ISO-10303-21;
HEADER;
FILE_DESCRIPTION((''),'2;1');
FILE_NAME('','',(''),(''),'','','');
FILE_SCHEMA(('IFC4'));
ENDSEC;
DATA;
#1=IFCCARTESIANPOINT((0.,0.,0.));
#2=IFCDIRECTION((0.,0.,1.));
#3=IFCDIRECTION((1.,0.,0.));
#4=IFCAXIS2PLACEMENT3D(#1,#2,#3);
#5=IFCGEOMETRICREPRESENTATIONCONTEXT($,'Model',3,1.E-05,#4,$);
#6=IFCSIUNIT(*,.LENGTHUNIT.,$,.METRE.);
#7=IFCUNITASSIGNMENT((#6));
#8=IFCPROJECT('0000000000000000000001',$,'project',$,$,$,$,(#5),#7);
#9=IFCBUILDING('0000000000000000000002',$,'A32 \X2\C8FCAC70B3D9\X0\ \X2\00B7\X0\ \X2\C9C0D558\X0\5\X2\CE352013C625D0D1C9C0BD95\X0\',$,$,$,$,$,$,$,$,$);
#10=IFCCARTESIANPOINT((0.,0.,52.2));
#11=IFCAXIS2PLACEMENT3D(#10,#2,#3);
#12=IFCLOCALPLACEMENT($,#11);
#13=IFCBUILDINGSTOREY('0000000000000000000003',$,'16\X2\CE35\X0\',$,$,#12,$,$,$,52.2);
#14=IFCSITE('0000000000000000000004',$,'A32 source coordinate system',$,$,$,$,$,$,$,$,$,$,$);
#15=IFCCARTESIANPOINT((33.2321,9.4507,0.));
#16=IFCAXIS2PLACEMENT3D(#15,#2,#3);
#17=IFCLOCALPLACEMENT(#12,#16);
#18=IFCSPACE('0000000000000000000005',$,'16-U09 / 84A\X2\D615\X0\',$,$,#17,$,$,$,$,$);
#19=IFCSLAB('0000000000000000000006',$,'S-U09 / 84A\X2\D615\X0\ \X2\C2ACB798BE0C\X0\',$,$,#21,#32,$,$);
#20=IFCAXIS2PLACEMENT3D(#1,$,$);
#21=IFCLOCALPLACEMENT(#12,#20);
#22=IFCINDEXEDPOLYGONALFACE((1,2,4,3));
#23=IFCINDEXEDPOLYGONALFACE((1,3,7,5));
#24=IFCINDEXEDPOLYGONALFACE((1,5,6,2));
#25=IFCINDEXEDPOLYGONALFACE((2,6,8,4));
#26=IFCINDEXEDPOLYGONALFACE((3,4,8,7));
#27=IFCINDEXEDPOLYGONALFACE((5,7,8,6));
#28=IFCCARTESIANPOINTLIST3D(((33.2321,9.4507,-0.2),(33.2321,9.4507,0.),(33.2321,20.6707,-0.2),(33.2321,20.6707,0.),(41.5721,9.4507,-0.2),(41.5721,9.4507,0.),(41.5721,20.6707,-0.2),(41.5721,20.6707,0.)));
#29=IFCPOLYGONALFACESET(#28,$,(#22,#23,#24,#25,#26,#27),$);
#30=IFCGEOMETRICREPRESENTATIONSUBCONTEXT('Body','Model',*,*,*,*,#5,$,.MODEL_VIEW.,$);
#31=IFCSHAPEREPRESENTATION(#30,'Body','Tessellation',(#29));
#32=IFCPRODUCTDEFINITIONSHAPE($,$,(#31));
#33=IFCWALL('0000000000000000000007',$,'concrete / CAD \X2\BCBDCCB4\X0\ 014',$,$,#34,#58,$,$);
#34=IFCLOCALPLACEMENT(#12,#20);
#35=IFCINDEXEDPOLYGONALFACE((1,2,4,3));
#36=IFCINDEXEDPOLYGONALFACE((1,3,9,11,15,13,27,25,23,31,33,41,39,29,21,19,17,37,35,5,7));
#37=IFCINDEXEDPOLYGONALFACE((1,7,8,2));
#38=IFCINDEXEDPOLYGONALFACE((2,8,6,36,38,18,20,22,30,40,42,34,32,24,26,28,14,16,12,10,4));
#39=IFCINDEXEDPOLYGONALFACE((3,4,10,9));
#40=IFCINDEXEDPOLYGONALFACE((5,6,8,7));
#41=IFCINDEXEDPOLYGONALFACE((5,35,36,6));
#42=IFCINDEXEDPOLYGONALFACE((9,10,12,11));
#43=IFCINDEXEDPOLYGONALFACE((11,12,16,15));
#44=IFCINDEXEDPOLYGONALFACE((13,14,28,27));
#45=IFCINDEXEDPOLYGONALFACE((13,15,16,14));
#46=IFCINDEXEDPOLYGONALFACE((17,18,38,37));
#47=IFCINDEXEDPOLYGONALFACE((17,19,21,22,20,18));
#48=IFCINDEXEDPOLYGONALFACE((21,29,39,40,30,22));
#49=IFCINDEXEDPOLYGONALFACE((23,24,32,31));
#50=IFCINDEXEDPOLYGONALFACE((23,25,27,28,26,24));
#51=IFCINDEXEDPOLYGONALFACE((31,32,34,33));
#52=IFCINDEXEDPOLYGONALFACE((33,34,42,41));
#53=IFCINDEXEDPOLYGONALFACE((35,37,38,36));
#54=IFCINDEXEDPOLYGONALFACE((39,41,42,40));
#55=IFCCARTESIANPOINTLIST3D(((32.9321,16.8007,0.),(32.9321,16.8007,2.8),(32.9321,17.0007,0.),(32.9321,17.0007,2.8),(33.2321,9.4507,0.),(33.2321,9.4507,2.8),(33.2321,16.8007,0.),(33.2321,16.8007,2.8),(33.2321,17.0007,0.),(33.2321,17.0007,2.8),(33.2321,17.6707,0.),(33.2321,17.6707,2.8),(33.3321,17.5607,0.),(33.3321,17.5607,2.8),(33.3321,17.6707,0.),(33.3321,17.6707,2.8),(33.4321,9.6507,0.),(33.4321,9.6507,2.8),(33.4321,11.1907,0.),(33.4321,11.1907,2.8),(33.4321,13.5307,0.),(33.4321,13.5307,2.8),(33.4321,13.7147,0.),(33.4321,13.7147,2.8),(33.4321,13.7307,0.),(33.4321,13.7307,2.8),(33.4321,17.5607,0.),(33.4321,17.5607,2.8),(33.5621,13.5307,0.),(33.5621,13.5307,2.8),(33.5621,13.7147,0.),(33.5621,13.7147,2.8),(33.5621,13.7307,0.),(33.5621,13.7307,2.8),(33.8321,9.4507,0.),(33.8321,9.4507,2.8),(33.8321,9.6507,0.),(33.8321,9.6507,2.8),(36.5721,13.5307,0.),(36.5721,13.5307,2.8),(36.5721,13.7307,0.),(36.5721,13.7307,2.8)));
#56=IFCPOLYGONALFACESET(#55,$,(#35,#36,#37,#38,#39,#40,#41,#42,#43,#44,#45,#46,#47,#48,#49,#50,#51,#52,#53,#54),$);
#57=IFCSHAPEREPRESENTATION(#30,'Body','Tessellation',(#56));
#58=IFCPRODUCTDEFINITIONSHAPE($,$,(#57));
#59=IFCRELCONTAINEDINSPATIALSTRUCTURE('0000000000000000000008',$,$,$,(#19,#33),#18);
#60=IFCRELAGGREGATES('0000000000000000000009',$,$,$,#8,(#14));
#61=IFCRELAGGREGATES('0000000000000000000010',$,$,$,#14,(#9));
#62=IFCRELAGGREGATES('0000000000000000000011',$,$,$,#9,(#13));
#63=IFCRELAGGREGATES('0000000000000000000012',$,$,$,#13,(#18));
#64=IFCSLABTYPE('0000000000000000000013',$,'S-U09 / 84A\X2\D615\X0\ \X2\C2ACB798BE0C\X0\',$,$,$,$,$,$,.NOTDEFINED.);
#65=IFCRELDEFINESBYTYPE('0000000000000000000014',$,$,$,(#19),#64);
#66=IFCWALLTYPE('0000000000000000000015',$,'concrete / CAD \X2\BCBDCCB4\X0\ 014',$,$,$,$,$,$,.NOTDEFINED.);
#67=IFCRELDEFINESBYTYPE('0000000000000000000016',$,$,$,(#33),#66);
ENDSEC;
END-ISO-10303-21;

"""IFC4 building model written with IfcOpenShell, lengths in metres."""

from ifc_helpers import new_model, si_unit, frame, origin, origin_with_axes, place, context, subcontext, project, spatial, polyline, outline, extrude, source, transform, mapped, type_object, type_shapes, element, save


model = new_model("IFC4")

# Units and contexts
model_context = context("Model", 3, precision=1e-05, world=origin_with_axes())
body_context = subcontext(model_context, "Body", "Model", "MODEL_VIEW")
ifc_project = project(units=[si_unit("LENGTHUNIT", "METRE")], contexts=[model_context])

# Site, building, storey, space
storey_placement = place(None, frame((0.0, 0.0, 52.2), z_axis=(0.0, 0.0, 1.0), x_axis=(1.0, 0.0, 0.0)))
space_placement = place(storey_placement, frame((33.2321, 9.4507, 0.0), z_axis=(0.0, 0.0, 1.0), x_axis=(1.0, 0.0, 0.0)))
site = spatial("IfcSite", under=ifc_project, Name="A32 source coordinate system")
building = spatial("IfcBuilding", under=site, Name="A32 주거동 · 지하5층–옥탑지붕")
storey = spatial("IfcBuildingStorey", under=building, at=storey_placement, Name="16층", Elevation=52.2)
space = spatial("IfcSpace", under=storey, at=space_placement, Name="16-U09 / 84A형")

# Slab
slab_type_1 = type_object("IfcSlabType", Name="S-U09 / 84A형 슬래브", PredefinedType="NOTDEFINED")
shared_shape_1 = source(origin(), body_context, "Body", "SweptSolid", [
    extrude(outline(polyline([(0.0, 11.22), (8.34, 11.22), (8.34, 0.0), (0.0, 0.0), (0.0, 11.22)])), frame((0.0, 0.0, -0.2)), (0.0, 0.0, 1.0), 0.2),
])
type_shapes(slab_type_1, [shared_shape_1])
slab_1_placement = place(space_placement, origin_with_axes())
element("IfcSlab", 1, at=slab_1_placement, inside=space, type_object=slab_type_1, Name="S-U09 / 84A형 슬래브", context=body_context, shape_type="MappedRepresentation", body=[
    mapped(shared_shape_1, transform((0.0, 0.0, 0.0), scale=1.0)),
])

# Wall
wall_type_1 = type_object("IfcWallType", Name="concrete / CAD 벽체 014", PredefinedType="NOTDEFINED")
shared_shape_2 = source(origin(), body_context, "Body", "SweptSolid", [
    extrude(outline(polyline([(3.34, 4.08), (0.33, 4.08), (0.2, 4.08), (0.2, 1.74), (0.2, 0.2), (0.6, 0.2), (0.6, 0.0), (0.0, 0.0), (0.0, 7.35), (-0.3, 7.35), (-0.3, 7.55), (0.0, 7.55), (0.0, 8.22), (0.1, 8.22), (0.1, 8.11), (0.2, 8.11), (0.2, 4.28), (0.2, 4.264), (0.33, 4.264), (0.33, 4.28), (3.34, 4.28), (3.34, 4.08)])), origin(), (0.0, 0.0, 1.0), 2.8),
])
type_shapes(wall_type_1, [shared_shape_2])
wall_1_placement = place(space_placement, origin_with_axes())
element("IfcWall", 2, at=wall_1_placement, inside=space, type_object=wall_type_1, Name="concrete / CAD 벽체 014", context=body_context, shape_type="MappedRepresentation", body=[
    mapped(shared_shape_2, transform((0.0, 0.0, 0.0), scale=1.0)),
])

save(model, "model.ifc")
